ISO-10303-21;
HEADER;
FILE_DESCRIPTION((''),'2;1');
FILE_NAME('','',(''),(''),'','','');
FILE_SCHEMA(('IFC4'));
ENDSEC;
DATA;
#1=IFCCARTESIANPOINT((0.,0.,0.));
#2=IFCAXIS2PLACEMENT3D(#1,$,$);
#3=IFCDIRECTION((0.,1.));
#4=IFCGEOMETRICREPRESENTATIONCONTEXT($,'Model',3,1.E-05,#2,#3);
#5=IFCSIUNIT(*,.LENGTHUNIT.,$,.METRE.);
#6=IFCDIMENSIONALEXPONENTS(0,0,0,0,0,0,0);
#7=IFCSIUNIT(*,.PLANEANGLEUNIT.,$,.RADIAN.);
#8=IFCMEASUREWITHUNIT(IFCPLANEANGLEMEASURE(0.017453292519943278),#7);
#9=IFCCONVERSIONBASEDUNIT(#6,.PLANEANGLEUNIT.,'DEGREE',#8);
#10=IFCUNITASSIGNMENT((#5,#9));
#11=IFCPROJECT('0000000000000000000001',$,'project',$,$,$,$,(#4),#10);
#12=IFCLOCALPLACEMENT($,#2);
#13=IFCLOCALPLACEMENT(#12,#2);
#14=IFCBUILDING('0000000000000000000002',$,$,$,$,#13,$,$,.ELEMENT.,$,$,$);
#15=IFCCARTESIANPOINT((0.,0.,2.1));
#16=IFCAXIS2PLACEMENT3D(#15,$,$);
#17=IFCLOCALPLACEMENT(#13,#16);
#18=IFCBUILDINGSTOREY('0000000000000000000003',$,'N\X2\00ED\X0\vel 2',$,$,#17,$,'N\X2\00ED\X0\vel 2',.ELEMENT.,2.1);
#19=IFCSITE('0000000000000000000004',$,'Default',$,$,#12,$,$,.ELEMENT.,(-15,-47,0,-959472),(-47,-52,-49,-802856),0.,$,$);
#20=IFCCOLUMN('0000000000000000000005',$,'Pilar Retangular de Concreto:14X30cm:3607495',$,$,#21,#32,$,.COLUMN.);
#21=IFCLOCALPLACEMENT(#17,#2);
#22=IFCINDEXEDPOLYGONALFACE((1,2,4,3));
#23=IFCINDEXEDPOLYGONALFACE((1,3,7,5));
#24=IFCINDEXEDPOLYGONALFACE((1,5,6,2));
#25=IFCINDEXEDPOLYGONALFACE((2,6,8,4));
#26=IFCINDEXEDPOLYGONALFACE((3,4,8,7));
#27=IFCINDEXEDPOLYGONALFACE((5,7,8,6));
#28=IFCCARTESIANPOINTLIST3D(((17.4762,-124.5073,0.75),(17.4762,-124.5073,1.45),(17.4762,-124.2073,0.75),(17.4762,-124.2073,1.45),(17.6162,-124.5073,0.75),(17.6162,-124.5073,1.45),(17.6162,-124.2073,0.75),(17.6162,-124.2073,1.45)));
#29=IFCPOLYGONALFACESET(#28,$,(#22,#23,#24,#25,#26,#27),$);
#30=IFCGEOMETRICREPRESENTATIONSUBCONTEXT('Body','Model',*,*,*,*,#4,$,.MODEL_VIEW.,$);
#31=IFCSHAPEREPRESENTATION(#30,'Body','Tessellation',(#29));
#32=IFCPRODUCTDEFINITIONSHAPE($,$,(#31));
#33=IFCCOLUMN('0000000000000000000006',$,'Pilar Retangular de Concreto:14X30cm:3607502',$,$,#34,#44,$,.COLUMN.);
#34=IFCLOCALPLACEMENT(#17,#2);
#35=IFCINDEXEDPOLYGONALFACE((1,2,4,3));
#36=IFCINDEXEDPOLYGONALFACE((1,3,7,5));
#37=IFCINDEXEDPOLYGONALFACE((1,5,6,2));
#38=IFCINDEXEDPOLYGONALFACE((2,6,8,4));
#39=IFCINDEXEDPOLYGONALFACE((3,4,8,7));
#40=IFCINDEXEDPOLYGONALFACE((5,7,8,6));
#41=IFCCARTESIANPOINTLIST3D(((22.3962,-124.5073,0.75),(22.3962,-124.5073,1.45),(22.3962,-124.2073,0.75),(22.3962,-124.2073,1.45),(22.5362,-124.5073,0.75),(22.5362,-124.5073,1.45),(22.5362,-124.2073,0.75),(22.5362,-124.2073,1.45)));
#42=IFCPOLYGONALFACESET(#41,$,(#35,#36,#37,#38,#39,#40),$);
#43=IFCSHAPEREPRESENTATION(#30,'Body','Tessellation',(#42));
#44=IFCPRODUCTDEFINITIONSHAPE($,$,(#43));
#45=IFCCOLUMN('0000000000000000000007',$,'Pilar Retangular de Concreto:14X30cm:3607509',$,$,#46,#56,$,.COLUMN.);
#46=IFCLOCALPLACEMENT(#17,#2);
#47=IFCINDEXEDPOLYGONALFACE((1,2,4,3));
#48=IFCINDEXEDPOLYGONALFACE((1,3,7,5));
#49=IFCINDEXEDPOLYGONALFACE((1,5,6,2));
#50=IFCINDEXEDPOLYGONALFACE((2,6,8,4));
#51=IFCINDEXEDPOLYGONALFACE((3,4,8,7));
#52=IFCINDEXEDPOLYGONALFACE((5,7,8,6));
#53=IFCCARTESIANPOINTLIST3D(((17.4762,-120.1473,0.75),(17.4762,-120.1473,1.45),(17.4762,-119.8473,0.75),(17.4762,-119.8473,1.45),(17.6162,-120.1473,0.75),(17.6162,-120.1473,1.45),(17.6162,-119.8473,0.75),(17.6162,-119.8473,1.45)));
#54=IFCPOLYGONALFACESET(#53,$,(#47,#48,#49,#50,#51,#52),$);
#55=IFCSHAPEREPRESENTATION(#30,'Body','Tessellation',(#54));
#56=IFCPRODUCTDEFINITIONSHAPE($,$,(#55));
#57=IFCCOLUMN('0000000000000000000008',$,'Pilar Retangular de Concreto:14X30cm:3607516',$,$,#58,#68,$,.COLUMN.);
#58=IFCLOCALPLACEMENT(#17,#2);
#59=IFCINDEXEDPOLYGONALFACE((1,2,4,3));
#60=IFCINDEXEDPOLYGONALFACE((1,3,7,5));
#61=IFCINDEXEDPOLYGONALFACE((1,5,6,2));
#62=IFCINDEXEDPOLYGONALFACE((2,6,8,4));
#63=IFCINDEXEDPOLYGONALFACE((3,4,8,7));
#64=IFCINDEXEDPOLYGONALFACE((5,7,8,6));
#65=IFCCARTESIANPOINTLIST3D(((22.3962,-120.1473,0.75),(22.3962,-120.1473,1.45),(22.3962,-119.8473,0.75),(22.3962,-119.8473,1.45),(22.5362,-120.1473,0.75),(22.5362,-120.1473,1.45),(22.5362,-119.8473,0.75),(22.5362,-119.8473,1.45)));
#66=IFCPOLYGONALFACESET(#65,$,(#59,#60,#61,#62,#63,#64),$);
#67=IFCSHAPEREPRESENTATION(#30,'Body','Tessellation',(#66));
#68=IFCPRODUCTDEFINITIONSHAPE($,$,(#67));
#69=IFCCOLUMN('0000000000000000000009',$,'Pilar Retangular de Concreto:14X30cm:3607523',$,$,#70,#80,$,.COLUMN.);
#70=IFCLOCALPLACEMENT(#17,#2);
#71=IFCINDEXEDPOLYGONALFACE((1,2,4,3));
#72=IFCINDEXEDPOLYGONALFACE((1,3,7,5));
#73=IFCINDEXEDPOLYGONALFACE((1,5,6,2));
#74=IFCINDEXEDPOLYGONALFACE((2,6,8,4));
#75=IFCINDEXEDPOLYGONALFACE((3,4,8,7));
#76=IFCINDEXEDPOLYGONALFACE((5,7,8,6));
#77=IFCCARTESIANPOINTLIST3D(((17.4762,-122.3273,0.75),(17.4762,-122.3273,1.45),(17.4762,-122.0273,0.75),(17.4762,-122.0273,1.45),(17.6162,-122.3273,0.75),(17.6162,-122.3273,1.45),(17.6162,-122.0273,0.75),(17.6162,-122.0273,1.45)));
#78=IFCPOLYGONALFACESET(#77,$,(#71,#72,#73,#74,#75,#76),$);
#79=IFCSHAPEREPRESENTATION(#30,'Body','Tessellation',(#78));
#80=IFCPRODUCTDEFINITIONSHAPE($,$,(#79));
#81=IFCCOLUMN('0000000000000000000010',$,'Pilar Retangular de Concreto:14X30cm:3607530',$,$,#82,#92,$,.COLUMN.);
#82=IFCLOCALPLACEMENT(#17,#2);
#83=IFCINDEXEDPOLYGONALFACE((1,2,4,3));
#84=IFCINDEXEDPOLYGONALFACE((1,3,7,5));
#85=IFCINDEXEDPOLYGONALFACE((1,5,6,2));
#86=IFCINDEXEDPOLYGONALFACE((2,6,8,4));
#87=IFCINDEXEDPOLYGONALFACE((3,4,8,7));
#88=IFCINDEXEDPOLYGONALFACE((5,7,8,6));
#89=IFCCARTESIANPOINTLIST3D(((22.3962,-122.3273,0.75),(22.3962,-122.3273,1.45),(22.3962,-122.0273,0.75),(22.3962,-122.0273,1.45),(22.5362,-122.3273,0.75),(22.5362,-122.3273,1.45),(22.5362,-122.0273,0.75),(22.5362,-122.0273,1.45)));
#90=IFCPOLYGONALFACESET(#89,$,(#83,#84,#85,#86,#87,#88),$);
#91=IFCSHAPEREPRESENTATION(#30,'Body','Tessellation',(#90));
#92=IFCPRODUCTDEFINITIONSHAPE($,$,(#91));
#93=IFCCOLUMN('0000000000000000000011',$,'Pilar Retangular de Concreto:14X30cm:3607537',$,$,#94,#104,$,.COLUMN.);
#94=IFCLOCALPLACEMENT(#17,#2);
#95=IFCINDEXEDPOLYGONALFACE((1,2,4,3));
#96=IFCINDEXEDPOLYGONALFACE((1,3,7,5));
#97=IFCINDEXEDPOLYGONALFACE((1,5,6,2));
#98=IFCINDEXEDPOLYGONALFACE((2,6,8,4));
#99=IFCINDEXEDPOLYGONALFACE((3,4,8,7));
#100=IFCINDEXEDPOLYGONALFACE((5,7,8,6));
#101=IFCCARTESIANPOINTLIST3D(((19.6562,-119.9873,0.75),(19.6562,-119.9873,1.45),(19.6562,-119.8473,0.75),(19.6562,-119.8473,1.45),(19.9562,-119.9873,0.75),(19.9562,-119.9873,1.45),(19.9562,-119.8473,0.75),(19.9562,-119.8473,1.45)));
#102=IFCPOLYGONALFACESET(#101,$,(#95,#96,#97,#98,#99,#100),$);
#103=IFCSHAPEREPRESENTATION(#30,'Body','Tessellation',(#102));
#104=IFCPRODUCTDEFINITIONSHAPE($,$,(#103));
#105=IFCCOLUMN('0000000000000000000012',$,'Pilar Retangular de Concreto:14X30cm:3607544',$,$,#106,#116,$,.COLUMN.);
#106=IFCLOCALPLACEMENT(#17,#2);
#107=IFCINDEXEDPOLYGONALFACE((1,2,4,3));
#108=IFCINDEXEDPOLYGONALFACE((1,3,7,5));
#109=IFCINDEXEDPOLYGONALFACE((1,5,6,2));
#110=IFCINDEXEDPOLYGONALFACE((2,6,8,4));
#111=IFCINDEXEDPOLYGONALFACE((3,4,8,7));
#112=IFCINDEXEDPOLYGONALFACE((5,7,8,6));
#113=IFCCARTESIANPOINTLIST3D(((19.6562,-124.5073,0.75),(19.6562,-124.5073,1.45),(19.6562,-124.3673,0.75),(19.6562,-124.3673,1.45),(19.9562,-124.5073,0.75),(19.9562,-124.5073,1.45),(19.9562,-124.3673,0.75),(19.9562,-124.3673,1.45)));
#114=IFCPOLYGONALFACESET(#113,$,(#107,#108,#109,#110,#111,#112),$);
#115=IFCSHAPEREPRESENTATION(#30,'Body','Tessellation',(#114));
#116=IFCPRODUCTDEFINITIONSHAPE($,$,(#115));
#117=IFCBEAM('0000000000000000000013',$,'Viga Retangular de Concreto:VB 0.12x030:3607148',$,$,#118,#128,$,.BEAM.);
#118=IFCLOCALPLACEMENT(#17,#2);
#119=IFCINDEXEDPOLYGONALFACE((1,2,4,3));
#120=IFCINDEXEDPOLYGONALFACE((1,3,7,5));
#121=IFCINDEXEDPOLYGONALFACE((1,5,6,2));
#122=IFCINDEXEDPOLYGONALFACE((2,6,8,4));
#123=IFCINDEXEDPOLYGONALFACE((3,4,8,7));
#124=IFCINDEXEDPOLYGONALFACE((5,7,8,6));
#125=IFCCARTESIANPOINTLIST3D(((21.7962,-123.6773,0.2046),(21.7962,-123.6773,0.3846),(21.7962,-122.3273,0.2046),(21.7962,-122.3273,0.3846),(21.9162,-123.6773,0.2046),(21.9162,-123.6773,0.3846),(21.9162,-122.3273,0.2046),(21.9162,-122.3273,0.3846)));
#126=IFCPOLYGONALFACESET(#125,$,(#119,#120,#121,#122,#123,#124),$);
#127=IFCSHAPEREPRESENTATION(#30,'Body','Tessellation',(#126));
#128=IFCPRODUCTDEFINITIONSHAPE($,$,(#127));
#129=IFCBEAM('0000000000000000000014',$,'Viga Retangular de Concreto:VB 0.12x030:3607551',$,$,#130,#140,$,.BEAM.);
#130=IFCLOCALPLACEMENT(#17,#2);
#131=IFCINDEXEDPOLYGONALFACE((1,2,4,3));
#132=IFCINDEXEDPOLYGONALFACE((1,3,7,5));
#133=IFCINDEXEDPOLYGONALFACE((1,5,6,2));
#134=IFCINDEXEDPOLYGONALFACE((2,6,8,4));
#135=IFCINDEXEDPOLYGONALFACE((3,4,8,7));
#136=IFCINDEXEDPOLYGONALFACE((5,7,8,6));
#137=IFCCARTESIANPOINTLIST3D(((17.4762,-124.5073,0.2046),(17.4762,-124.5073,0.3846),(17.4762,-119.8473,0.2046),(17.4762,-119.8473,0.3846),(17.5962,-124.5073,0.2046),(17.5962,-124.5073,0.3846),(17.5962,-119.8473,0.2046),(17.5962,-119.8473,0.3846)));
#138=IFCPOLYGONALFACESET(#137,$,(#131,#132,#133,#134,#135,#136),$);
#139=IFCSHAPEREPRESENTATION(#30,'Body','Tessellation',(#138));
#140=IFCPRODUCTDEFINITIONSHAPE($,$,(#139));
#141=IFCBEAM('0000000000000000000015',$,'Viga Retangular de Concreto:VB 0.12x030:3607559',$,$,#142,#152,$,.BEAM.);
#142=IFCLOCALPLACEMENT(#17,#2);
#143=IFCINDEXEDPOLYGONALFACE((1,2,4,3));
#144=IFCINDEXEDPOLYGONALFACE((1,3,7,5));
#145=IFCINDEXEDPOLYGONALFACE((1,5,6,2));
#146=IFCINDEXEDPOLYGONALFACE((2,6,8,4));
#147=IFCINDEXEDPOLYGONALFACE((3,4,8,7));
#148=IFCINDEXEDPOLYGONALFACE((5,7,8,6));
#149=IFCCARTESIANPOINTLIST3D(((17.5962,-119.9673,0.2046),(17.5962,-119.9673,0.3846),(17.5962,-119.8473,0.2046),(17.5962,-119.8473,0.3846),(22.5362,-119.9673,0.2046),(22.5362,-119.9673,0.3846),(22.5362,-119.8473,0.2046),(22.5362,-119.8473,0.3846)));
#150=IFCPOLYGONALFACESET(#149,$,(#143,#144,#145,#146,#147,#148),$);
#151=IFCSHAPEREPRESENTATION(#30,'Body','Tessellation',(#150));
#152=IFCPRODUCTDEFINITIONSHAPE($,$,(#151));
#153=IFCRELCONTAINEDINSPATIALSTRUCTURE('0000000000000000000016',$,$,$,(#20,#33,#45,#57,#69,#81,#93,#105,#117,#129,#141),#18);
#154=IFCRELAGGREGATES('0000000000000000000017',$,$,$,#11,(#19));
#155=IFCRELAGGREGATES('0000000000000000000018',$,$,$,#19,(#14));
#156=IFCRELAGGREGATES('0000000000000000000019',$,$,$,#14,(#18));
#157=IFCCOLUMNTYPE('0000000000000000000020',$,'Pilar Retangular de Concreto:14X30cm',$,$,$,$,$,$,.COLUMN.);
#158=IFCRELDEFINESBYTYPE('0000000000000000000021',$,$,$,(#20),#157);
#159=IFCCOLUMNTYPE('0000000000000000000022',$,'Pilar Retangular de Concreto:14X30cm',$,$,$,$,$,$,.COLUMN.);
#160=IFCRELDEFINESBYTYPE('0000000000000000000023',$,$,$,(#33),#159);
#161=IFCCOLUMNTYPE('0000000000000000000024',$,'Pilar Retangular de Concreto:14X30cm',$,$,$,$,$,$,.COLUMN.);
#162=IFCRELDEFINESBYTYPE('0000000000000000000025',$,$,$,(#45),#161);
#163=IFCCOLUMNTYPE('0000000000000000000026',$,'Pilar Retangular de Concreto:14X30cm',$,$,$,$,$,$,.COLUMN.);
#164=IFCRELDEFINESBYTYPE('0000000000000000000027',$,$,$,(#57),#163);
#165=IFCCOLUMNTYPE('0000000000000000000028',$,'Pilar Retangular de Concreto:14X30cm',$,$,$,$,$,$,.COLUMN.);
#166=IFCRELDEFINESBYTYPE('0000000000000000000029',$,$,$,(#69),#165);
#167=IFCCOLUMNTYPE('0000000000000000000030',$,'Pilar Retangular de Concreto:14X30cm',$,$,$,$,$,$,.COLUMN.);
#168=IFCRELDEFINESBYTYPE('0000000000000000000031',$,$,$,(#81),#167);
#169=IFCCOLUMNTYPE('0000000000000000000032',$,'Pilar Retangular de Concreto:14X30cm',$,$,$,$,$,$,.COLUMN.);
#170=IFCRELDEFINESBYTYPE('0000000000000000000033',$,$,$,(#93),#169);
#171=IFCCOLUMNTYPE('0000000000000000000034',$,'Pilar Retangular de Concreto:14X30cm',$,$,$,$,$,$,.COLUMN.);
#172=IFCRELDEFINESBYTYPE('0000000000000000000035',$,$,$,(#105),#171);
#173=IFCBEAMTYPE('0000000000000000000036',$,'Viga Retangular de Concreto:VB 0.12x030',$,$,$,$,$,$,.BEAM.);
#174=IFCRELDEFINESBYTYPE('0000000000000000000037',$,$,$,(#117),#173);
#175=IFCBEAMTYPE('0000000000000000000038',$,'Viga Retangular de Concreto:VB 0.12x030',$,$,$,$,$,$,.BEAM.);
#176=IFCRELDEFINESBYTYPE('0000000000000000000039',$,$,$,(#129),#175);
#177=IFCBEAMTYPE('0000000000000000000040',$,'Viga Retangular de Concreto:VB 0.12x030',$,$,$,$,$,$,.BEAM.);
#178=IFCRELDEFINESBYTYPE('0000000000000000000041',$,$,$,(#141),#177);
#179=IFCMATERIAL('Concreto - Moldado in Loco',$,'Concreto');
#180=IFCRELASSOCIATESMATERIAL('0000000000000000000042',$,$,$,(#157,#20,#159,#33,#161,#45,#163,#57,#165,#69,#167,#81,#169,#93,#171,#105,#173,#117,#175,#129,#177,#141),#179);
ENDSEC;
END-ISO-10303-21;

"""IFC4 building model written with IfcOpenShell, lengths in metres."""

from ifc_helpers import new_model, entity, si_unit, converted_unit, direction, frame, origin, place, context, subcontext, project, spatial, indexed_curve, outline, extrude, source, transform, mapped, material, type_object, type_shapes, element, save


model = new_model("IFC4")

# Units and contexts
model_context = context("Model", 3, precision=1e-05, world=origin(), true_north=direction((0.0, 1.0)))
body_context = subcontext(model_context, "Body", "Model", "MODEL_VIEW")
ifc_project = project(units=[si_unit("LENGTHUNIT", "METRE"), converted_unit("PLANEANGLEUNIT", "DEGREE", entity("IfcPlaneAngleMeasure", 0.017453292519943278), si_unit("PLANEANGLEUNIT", "RADIAN"), dimensions=[0, 0, 0, 0, 0, 0, 0])], contexts=[model_context])

# Site, building, storey
site_placement = place(None, origin())
site = spatial("IfcSite", under=ifc_project, at=site_placement, Name="Default", CompositionType="ELEMENT", RefLatitude=(-15, -47, 0, -959472), RefLongitude=(-47, -52, -49, -802856), RefElevation=0.0)
building_placement = place(site_placement, origin())
building = spatial("IfcBuilding", under=site, at=building_placement, CompositionType="ELEMENT")
storey_placement = place(building_placement, frame((0.0, 0.0, 2.1)))
storey = spatial("IfcBuildingStorey", under=building, at=storey_placement, Name="Nível 2", LongName="Nível 2", CompositionType="ELEMENT", Elevation=2.1)

# Columns
ifc_material_1 = material(Name="Concreto - Moldado in Loco", Category="Concreto")
column_type_1 = type_object("IfcColumnType", Name="Pilar Retangular de Concreto:14X30cm", PredefinedType="COLUMN", material=ifc_material_1)
shared_shape_1 = source(origin(), body_context, "Body", "SweptSolid", [
    extrude(outline(indexed_curve([(-0.07, -0.15), (0.07, -0.15), (0.07, 0.15), (-0.07, 0.15), (-0.07, -0.15)], self_intersect=False)), frame((17.5462, -124.3573, 2.85), z_axis=(0.0, 0.0, 1.0), x_axis=(-1.0, 0.0, 0.0)), (0.0, 0.0, 1.0), 0.7),
])
type_shapes(column_type_1, [shared_shape_1])
column_1_placement = place(storey_placement, frame((0.0, 0.0, -2.1)))
element("IfcColumn", 1, at=column_1_placement, inside=storey, type_object=column_type_1, material=ifc_material_1, Name="Pilar Retangular de Concreto:14X30cm:3607495", PredefinedType="COLUMN", context=body_context, shape_type="MappedRepresentation", body=[
    mapped(shared_shape_1, transform((0.0, 0.0, 0.0), scale=1.0)),
])
column_type_2 = type_object("IfcColumnType", Name="Pilar Retangular de Concreto:14X30cm", PredefinedType="COLUMN", material=ifc_material_1)
shared_shape_2 = source(origin(), body_context, "Body", "SweptSolid", [
    extrude(outline(indexed_curve([(-0.07, -0.15), (0.07, -0.15), (0.07, 0.15), (-0.07, 0.15), (-0.07, -0.15)], self_intersect=False)), frame((22.4662, -124.3573, 2.85), z_axis=(0.0, 0.0, 1.0), x_axis=(-1.0, 0.0, 0.0)), (0.0, 0.0, 1.0), 0.7),
])
type_shapes(column_type_2, [shared_shape_2])
column_2_placement = place(storey_placement, frame((0.0, 0.0, -2.1)))
element("IfcColumn", 2, at=column_2_placement, inside=storey, type_object=column_type_2, material=ifc_material_1, Name="Pilar Retangular de Concreto:14X30cm:3607502", PredefinedType="COLUMN", context=body_context, shape_type="MappedRepresentation", body=[
    mapped(shared_shape_2, transform((0.0, 0.0, 0.0), scale=1.0)),
])
column_type_3 = type_object("IfcColumnType", Name="Pilar Retangular de Concreto:14X30cm", PredefinedType="COLUMN", material=ifc_material_1)
shared_shape_3 = source(origin(), body_context, "Body", "SweptSolid", [
    extrude(outline(indexed_curve([(-0.07, -0.15), (0.07, -0.15), (0.07, 0.15), (-0.07, 0.15), (-0.07, -0.15)], self_intersect=False)), frame((17.5462, -119.9973, 2.85), z_axis=(0.0, 0.0, 1.0), x_axis=(-1.0, 0.0, 0.0)), (0.0, 0.0, 1.0), 0.7),
])
type_shapes(column_type_3, [shared_shape_3])
column_3_placement = place(storey_placement, frame((0.0, 0.0, -2.1)))
element("IfcColumn", 3, at=column_3_placement, inside=storey, type_object=column_type_3, material=ifc_material_1, Name="Pilar Retangular de Concreto:14X30cm:3607509", PredefinedType="COLUMN", context=body_context, shape_type="MappedRepresentation", body=[
    mapped(shared_shape_3, transform((0.0, 0.0, 0.0), scale=1.0)),
])
column_type_4 = type_object("IfcColumnType", Name="Pilar Retangular de Concreto:14X30cm", PredefinedType="COLUMN", material=ifc_material_1)
shared_shape_4 = source(origin(), body_context, "Body", "SweptSolid", [
    extrude(outline(indexed_curve([(-0.07, -0.15), (0.07, -0.15), (0.07, 0.15), (-0.07, 0.15), (-0.07, -0.15)], self_intersect=False)), frame((22.4662, -119.9973, 2.85), z_axis=(0.0, 0.0, 1.0), x_axis=(-1.0, 0.0, 0.0)), (0.0, 0.0, 1.0), 0.7),
])
type_shapes(column_type_4, [shared_shape_4])
column_4_placement = place(storey_placement, frame((0.0, 0.0, -2.1)))
element("IfcColumn", 4, at=column_4_placement, inside=storey, type_object=column_type_4, material=ifc_material_1, Name="Pilar Retangular de Concreto:14X30cm:3607516", PredefinedType="COLUMN", context=body_context, shape_type="MappedRepresentation", body=[
    mapped(shared_shape_4, transform((0.0, 0.0, 0.0), scale=1.0)),
])
column_type_5 = type_object("IfcColumnType", Name="Pilar Retangular de Concreto:14X30cm", PredefinedType="COLUMN", material=ifc_material_1)
shared_shape_5 = source(origin(), body_context, "Body", "SweptSolid", [
    extrude(outline(indexed_curve([(-0.07, -0.15), (0.07, -0.15), (0.07, 0.15), (-0.07, 0.15), (-0.07, -0.15)], self_intersect=False)), frame((17.5462, -122.1773, 2.85), z_axis=(0.0, 0.0, 1.0), x_axis=(-1.0, 0.0, 0.0)), (0.0, 0.0, 1.0), 0.7),
])
type_shapes(column_type_5, [shared_shape_5])
column_5_placement = place(storey_placement, frame((0.0, 0.0, -2.1)))
element("IfcColumn", 5, at=column_5_placement, inside=storey, type_object=column_type_5, material=ifc_material_1, Name="Pilar Retangular de Concreto:14X30cm:3607523", PredefinedType="COLUMN", context=body_context, shape_type="MappedRepresentation", body=[
    mapped(shared_shape_5, transform((0.0, 0.0, 0.0), scale=1.0)),
])
column_type_6 = type_object("IfcColumnType", Name="Pilar Retangular de Concreto:14X30cm", PredefinedType="COLUMN", material=ifc_material_1)
shared_shape_6 = source(origin(), body_context, "Body", "SweptSolid", [
    extrude(outline(indexed_curve([(-0.07, -0.15), (0.07, -0.15), (0.07, 0.15), (-0.07, 0.15), (-0.07, -0.15)], self_intersect=False)), frame((22.4662, -122.1773, 2.85), z_axis=(0.0, 0.0, 1.0), x_axis=(-1.0, 0.0, 0.0)), (0.0, 0.0, 1.0), 0.7),
])
type_shapes(column_type_6, [shared_shape_6])
column_6_placement = place(storey_placement, frame((0.0, 0.0, -2.1)))
element("IfcColumn", 6, at=column_6_placement, inside=storey, type_object=column_type_6, material=ifc_material_1, Name="Pilar Retangular de Concreto:14X30cm:3607530", PredefinedType="COLUMN", context=body_context, shape_type="MappedRepresentation", body=[
    mapped(shared_shape_6, transform((0.0, 0.0, 0.0), scale=1.0)),
])
column_type_7 = type_object("IfcColumnType", Name="Pilar Retangular de Concreto:14X30cm", PredefinedType="COLUMN", material=ifc_material_1)
shared_shape_7 = source(origin(), body_context, "Body", "SweptSolid", [
    extrude(outline(indexed_curve([(-0.07, -0.15), (0.07, -0.15), (0.07, 0.15), (-0.07, 0.15), (-0.07, -0.15)], self_intersect=False)), frame((19.8062, -119.9173, 2.85), z_axis=(0.0, 0.0, 1.0), x_axis=(0.0, -1.0, 0.0)), (0.0, 0.0, 1.0), 0.7),
])
type_shapes(column_type_7, [shared_shape_7])
column_7_placement = place(storey_placement, frame((0.0, 0.0, -2.1)))
element("IfcColumn", 7, at=column_7_placement, inside=storey, type_object=column_type_7, material=ifc_material_1, Name="Pilar Retangular de Concreto:14X30cm:3607537", PredefinedType="COLUMN", context=body_context, shape_type="MappedRepresentation", body=[
    mapped(shared_shape_7, transform((0.0, 0.0, 0.0), scale=1.0)),
])
column_type_8 = type_object("IfcColumnType", Name="Pilar Retangular de Concreto:14X30cm", PredefinedType="COLUMN", material=ifc_material_1)
shared_shape_8 = source(origin(), body_context, "Body", "SweptSolid", [
    extrude(outline(indexed_curve([(-0.07, -0.15), (0.07, -0.15), (0.07, 0.15), (-0.07, 0.15), (-0.07, -0.15)], self_intersect=False)), frame((19.8062, -124.4373, 2.85), z_axis=(0.0, 0.0, 1.0), x_axis=(0.0, -1.0, 0.0)), (0.0, 0.0, 1.0), 0.7),
])
type_shapes(column_type_8, [shared_shape_8])
column_8_placement = place(storey_placement, frame((0.0, 0.0, -2.1)))
element("IfcColumn", 8, at=column_8_placement, inside=storey, type_object=column_type_8, material=ifc_material_1, Name="Pilar Retangular de Concreto:14X30cm:3607544", PredefinedType="COLUMN", context=body_context, shape_type="MappedRepresentation", body=[
    mapped(shared_shape_8, transform((0.0, 0.0, 0.0), scale=1.0)),
])

# Beams
beam_type_1 = type_object("IfcBeamType", Name="Viga Retangular de Concreto:VB 0.12x030", PredefinedType="BEAM", material=ifc_material_1)
shared_shape_9 = source(origin(), body_context, "Body", "SweptSolid", [
    extrude(outline(indexed_curve([(-0.06, -0.09), (0.06, -0.09), (0.06, 0.09), (-0.06, 0.09), (-0.06, -0.09)], self_intersect=False)), frame((21.8562, -123.6773, 2.3946), z_axis=(0.0, 1.0, 0.0), x_axis=(-1.0, 0.0, 0.0)), (0.0, 0.0, 1.0), 1.35),
])
type_shapes(beam_type_1, [shared_shape_9])
beam_1_placement = place(storey_placement, frame((0.0, 0.0, -2.1)))
element("IfcBeam", 9, at=beam_1_placement, inside=storey, type_object=beam_type_1, material=ifc_material_1, Name="Viga Retangular de Concreto:VB 0.12x030:3607148", PredefinedType="BEAM", context=body_context, shape_type="MappedRepresentation", body=[
    mapped(shared_shape_9, transform((0.0, 0.0, 0.0), scale=1.0)),
])
beam_type_2 = type_object("IfcBeamType", Name="Viga Retangular de Concreto:VB 0.12x030", PredefinedType="BEAM", material=ifc_material_1)
shared_shape_10 = source(origin(), body_context, "Body", "SweptSolid", [
    extrude(outline(indexed_curve([(-0.06, -0.09), (0.06, -0.09), (0.06, 0.09), (-0.06, 0.09), (-0.06, -0.09)], self_intersect=False)), frame((17.5362, -124.5073, 2.3946), z_axis=(0.0, 1.0, 0.0), x_axis=(-1.0, 0.0, 0.0)), (0.0, 0.0, 1.0), 4.66),
])
type_shapes(beam_type_2, [shared_shape_10])
beam_2_placement = place(storey_placement, frame((0.0, 0.0, -2.1)))
element("IfcBeam", 10, at=beam_2_placement, inside=storey, type_object=beam_type_2, material=ifc_material_1, Name="Viga Retangular de Concreto:VB 0.12x030:3607551", PredefinedType="BEAM", context=body_context, shape_type="MappedRepresentation", body=[
    mapped(shared_shape_10, transform((0.0, 0.0, 0.0), scale=1.0)),
])
beam_type_3 = type_object("IfcBeamType", Name="Viga Retangular de Concreto:VB 0.12x030", PredefinedType="BEAM", material=ifc_material_1)
shared_shape_11 = source(origin(), body_context, "Body", "SweptSolid", [
    extrude(outline(indexed_curve([(-0.09, -0.06), (0.09, -0.06), (0.09, 0.06), (-0.09, 0.06), (-0.09, -0.06)], self_intersect=False)), frame((17.5962, -119.9073, 2.3946), z_axis=(1.0, 0.0, 0.0), x_axis=(0.0, 0.0, -1.0)), (0.0, 0.0, 1.0), 4.94),
])
type_shapes(beam_type_3, [shared_shape_11])
beam_3_placement = place(storey_placement, frame((0.0, 0.0, -2.1)))
element("IfcBeam", 11, at=beam_3_placement, inside=storey, type_object=beam_type_3, material=ifc_material_1, Name="Viga Retangular de Concreto:VB 0.12x030:3607559", PredefinedType="BEAM", context=body_context, shape_type="MappedRepresentation", body=[
    mapped(shared_shape_11, transform((0.0, 0.0, 0.0), scale=1.0)),
])

save(model, "model.ifc")
